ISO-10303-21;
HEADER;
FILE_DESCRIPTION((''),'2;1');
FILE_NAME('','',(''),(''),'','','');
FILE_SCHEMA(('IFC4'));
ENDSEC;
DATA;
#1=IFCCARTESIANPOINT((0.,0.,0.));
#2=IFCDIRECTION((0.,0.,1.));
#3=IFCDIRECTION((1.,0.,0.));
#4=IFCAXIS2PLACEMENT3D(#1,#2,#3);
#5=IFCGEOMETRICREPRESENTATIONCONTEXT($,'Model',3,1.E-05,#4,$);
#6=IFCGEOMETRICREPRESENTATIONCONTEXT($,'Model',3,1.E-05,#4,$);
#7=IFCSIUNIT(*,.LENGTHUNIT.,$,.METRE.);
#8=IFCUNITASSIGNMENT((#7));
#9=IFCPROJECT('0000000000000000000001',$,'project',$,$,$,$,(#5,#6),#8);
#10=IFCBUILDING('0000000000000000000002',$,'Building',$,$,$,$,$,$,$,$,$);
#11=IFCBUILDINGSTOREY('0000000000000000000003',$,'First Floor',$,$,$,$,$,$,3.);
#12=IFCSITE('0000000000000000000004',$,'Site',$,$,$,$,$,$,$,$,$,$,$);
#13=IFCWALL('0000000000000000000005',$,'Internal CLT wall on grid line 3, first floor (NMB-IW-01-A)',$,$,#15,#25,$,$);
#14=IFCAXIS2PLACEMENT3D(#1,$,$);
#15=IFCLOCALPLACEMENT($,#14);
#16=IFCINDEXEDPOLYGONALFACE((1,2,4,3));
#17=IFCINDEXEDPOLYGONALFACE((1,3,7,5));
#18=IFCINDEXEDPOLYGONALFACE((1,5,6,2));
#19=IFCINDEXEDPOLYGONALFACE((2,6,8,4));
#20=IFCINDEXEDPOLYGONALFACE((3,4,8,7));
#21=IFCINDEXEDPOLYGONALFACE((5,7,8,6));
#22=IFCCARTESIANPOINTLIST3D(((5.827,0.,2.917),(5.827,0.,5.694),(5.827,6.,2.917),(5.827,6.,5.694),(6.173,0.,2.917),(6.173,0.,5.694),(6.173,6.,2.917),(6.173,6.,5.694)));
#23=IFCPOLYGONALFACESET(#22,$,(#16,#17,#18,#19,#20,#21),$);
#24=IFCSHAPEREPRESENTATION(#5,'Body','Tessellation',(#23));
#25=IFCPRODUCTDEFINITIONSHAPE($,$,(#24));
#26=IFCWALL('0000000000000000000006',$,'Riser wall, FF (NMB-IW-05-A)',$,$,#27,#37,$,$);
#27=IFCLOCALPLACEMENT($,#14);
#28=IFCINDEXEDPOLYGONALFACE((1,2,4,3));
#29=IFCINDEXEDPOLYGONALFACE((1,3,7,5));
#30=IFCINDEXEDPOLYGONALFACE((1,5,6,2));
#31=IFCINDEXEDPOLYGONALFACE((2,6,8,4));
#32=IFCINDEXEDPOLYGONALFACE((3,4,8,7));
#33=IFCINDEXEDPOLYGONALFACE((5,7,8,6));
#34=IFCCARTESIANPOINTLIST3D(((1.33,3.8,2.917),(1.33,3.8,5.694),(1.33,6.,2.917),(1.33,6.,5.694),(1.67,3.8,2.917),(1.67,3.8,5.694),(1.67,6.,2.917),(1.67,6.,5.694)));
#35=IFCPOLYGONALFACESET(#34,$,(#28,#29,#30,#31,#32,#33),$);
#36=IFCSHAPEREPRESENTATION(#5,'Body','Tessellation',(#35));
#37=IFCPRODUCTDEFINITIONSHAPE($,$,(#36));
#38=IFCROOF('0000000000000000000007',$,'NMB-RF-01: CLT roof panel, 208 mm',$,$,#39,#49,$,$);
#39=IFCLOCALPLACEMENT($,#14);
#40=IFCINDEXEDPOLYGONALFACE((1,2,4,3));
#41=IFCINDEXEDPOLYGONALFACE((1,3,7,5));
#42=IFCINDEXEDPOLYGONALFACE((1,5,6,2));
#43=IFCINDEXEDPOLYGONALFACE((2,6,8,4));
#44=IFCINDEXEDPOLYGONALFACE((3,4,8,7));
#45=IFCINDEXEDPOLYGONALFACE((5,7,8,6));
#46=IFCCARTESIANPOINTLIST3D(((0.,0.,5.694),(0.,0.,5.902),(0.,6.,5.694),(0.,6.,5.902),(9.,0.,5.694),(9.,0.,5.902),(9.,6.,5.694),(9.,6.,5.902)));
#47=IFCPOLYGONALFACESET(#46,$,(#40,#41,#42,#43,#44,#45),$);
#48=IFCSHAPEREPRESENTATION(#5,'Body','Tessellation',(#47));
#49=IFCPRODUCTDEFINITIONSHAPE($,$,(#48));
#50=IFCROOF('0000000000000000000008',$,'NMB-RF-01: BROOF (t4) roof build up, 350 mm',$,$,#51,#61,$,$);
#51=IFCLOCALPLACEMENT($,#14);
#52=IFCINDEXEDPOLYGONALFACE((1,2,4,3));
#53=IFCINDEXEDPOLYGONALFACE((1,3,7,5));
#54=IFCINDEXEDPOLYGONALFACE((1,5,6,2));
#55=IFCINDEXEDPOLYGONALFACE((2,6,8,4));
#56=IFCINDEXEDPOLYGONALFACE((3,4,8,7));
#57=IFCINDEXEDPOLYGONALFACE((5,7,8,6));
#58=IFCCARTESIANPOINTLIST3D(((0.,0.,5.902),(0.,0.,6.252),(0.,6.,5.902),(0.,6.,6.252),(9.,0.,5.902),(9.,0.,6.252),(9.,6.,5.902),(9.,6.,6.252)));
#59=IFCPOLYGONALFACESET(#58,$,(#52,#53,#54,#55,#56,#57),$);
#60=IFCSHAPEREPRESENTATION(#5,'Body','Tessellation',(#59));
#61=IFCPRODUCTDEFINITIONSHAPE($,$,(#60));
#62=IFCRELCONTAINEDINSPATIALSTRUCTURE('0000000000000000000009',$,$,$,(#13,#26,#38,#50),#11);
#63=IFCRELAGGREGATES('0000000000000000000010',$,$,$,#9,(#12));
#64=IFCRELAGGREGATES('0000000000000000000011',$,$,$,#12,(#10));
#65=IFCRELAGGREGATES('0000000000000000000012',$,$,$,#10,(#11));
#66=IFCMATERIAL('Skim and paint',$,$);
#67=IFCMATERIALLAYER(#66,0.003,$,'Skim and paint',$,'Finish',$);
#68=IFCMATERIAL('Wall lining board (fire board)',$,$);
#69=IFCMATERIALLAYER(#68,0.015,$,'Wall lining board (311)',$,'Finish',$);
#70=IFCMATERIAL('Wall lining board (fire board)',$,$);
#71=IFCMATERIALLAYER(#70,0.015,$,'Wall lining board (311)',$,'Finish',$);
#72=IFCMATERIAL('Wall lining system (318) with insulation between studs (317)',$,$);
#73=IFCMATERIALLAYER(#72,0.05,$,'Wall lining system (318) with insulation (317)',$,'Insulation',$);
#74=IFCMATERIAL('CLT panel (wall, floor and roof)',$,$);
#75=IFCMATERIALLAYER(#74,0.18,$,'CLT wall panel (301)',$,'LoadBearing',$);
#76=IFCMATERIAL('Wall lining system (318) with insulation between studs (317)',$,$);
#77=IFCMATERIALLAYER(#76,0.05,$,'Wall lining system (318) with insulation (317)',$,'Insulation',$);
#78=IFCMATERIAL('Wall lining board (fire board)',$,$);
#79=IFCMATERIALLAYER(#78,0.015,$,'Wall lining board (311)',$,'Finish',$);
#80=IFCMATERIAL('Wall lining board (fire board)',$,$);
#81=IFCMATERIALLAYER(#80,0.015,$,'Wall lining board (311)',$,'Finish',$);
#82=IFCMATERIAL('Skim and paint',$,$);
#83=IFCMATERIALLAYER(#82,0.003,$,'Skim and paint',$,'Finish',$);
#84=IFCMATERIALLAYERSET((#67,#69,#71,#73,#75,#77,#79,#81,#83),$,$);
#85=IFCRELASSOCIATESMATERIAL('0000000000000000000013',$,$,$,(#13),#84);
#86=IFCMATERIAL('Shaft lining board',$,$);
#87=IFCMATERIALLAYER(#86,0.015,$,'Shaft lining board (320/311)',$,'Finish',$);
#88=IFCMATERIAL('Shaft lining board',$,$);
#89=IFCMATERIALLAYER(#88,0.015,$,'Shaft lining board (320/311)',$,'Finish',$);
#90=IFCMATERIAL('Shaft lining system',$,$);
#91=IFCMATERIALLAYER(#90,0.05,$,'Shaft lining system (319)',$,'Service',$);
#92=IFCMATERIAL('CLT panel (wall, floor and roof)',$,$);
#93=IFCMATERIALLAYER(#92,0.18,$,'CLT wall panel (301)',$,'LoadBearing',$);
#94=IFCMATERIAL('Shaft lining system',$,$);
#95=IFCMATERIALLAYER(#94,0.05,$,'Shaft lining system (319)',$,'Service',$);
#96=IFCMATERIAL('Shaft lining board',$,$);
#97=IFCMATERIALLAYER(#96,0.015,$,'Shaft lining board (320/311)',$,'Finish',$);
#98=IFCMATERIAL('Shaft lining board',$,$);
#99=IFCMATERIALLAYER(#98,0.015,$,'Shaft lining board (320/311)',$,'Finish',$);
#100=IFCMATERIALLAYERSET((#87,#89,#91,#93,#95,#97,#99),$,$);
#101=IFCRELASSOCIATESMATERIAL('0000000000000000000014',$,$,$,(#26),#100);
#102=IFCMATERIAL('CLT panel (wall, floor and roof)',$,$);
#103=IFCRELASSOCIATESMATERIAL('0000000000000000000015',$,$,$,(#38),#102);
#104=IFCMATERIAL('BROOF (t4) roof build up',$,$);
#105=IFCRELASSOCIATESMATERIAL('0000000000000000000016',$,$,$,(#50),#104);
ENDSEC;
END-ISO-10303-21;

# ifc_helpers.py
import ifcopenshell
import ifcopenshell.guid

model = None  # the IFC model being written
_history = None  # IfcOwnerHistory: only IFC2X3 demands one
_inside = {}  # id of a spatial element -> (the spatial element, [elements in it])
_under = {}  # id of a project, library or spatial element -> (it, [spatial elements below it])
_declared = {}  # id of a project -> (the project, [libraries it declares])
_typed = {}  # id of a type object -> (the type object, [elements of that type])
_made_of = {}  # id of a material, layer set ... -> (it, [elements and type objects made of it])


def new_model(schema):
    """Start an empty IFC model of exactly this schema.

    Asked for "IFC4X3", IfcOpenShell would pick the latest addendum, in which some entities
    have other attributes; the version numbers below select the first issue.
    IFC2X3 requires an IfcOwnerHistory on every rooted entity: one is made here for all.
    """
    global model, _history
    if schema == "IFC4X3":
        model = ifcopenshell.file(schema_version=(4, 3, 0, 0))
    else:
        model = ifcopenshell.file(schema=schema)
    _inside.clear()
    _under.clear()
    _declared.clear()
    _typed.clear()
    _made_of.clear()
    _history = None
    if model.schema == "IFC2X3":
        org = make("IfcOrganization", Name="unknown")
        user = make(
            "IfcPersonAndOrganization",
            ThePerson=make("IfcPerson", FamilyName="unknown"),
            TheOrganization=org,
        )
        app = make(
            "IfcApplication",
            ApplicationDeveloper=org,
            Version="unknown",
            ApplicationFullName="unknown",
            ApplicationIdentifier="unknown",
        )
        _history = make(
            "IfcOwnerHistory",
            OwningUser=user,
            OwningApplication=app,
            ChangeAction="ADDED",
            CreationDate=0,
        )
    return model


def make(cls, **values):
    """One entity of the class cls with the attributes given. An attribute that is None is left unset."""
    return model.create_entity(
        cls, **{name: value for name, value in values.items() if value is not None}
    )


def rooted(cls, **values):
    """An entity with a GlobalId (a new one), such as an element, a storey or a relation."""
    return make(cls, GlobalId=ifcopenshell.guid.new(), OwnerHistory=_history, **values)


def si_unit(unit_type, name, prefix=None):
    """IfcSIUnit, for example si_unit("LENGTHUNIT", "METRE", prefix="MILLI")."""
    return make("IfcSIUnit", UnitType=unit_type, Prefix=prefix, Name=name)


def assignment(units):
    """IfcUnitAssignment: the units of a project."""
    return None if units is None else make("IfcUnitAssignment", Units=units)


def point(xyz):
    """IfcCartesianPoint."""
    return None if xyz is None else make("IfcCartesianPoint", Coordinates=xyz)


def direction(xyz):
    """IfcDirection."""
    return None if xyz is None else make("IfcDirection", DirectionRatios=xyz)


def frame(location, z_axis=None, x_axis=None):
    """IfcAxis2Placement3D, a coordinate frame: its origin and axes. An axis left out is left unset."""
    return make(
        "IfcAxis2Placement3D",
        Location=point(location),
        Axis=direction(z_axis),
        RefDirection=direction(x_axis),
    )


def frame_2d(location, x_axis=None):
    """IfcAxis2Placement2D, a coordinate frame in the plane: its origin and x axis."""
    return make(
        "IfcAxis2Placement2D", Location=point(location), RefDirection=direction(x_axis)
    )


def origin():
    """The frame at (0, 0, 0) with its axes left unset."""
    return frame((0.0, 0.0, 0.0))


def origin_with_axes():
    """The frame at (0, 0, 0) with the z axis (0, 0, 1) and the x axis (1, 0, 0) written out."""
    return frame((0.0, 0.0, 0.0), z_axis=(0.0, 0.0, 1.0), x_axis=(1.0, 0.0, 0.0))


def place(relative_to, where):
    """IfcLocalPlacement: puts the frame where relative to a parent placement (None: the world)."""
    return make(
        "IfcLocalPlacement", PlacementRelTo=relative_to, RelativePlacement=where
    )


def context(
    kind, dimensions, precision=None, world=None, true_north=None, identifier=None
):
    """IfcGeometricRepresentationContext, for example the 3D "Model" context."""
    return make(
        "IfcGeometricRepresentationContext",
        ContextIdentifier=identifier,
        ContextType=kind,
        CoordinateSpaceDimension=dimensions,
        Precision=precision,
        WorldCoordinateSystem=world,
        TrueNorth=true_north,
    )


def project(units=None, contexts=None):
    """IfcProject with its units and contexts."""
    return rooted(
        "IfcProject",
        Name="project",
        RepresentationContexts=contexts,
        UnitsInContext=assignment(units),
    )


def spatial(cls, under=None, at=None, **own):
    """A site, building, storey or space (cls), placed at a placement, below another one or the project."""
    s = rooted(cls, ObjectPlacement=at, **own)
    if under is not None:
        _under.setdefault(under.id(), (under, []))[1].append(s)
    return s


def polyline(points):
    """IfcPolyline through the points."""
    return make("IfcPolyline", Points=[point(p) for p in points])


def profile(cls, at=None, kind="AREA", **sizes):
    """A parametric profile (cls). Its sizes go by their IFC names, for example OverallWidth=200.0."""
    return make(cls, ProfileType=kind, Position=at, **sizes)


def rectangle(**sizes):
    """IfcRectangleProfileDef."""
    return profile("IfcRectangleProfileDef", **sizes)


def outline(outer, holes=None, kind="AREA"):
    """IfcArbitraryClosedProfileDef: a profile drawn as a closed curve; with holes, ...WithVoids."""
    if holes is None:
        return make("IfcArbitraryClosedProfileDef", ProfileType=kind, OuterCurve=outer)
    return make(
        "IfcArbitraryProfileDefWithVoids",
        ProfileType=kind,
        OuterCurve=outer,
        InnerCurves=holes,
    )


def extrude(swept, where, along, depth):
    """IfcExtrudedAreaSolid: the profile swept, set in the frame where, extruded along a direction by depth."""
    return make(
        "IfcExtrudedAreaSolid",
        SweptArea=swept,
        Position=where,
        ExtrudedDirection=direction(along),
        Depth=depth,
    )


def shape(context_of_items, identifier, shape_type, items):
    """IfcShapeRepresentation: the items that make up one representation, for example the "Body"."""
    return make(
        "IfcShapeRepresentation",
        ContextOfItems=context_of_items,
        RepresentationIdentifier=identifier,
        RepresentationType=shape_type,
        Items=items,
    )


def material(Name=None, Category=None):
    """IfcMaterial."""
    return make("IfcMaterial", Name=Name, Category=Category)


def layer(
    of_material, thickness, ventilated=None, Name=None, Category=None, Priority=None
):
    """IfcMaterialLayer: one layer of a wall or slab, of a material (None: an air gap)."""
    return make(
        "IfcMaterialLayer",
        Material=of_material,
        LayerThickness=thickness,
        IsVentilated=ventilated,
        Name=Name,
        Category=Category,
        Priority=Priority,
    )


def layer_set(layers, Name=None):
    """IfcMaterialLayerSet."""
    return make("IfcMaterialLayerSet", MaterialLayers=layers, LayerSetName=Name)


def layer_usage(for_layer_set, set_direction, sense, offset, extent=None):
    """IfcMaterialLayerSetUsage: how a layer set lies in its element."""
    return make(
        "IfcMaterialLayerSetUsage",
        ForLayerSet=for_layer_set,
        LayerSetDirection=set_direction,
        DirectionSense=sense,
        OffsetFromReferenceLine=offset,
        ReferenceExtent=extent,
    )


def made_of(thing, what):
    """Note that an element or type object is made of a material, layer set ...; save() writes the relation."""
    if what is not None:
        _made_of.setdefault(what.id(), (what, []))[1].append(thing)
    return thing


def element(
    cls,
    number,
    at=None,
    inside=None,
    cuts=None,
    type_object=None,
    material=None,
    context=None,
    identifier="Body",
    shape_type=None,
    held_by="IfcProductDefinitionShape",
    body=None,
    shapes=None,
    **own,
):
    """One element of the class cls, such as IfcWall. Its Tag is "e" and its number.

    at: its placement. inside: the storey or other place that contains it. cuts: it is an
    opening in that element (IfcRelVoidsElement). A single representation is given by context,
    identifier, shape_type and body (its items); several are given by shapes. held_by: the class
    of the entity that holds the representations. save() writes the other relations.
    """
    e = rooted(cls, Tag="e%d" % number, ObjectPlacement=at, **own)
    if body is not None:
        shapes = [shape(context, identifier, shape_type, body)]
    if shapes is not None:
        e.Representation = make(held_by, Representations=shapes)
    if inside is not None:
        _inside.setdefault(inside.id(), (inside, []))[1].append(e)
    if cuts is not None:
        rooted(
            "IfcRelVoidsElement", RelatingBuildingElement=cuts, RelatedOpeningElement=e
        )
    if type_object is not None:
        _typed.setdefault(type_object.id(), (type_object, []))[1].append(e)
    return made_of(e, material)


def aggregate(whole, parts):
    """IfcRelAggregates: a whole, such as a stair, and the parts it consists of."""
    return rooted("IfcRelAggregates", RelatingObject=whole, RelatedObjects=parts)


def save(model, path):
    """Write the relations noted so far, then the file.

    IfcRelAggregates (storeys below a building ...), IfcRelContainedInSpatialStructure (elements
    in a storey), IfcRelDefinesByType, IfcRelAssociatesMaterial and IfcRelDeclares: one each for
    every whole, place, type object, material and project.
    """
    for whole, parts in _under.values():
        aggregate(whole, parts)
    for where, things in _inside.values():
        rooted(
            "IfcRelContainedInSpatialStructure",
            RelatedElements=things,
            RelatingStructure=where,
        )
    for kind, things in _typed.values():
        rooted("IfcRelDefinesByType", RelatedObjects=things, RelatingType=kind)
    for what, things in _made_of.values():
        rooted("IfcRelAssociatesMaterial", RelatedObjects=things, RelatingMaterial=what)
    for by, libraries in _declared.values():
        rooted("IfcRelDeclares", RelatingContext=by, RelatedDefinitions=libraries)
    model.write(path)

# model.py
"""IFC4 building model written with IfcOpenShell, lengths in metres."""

from ifc_helpers import new_model, si_unit, frame, frame_2d, origin, origin_with_axes, place, context, project, spatial, polyline, rectangle, outline, extrude, material, layer, layer_set, layer_usage, element, save


model = new_model("IFC4")

# Units and contexts
model_context_1 = context("Model", 3, precision=1e-05, world=origin_with_axes())
model_context_2 = context("Model", 3, precision=1e-05, world=origin_with_axes())
ifc_project = project(units=[si_unit("LENGTHUNIT", "METRE")], contexts=[model_context_1, model_context_2])

# Site, building, storey
site = spatial("IfcSite", under=ifc_project, Name="Site")
building = spatial("IfcBuilding", under=site, Name="Building")
storey = spatial("IfcBuildingStorey", under=building, Name="First Floor", Elevation=3.0)

# Walls
ifc_material_1 = material(Name="Skim and paint")
ifc_layer_1 = layer(ifc_material_1, 0.003, Name="Skim and paint", Category="Finish")
ifc_material_2 = material(Name="Wall lining board (fire board)")
ifc_layer_2 = layer(ifc_material_2, 0.015, Name="Wall lining board (311)", Category="Finish")
ifc_material_3 = material(Name="Wall lining board (fire board)")
ifc_layer_3 = layer(ifc_material_3, 0.015, Name="Wall lining board (311)", Category="Finish")
ifc_material_4 = material(Name="Wall lining system (318) with insulation between studs (317)")
ifc_layer_4 = layer(ifc_material_4, 0.05, Name="Wall lining system (318) with insulation (317)", Category="Insulation")
ifc_material_5 = material(Name="CLT panel (wall, floor and roof)")
ifc_layer_5 = layer(ifc_material_5, 0.18, Name="CLT wall panel (301)", Category="LoadBearing")
ifc_material_6 = material(Name="Wall lining system (318) with insulation between studs (317)")
ifc_layer_6 = layer(ifc_material_6, 0.05, Name="Wall lining system (318) with insulation (317)", Category="Insulation")
ifc_material_7 = material(Name="Wall lining board (fire board)")
ifc_layer_7 = layer(ifc_material_7, 0.015, Name="Wall lining board (311)", Category="Finish")
ifc_material_8 = material(Name="Wall lining board (fire board)")
ifc_layer_8 = layer(ifc_material_8, 0.015, Name="Wall lining board (311)", Category="Finish")
ifc_material_9 = material(Name="Skim and paint")
ifc_layer_9 = layer(ifc_material_9, 0.003, Name="Skim and paint", Category="Finish")
ifc_layer_set_1 = layer_set([ifc_layer_1, ifc_layer_2, ifc_layer_3, ifc_layer_4, ifc_layer_5, ifc_layer_6, ifc_layer_7, ifc_layer_8, ifc_layer_9])
ifc_layer_usage_1 = layer_usage(ifc_layer_set_1, "AXIS2", "NEGATIVE", 0.173)
wall_1_placement = place(None, frame((6.0, 0.0, 2.917), z_axis=(0.0, 0.0, 1.0), x_axis=(0.0, 1.0, 0.0)))
element("IfcWall", 1, at=wall_1_placement, inside=storey, material=ifc_layer_usage_1, Name="Internal CLT wall on grid line 3, first floor (NMB-IW-01-A)", context=model_context_1, shape_type="SweptSolid", body=[
    extrude(rectangle(XDim=0.346, YDim=2.777, at=frame_2d((0.0, 1.3885))), frame((0.0, 0.0, 0.0), z_axis=(1.0, 0.0, 0.0), x_axis=(0.0, 1.0, 0.0)), (0.0, 0.0, 1.0), 6.0),
])
ifc_material_10 = material(Name="Shaft lining board")
ifc_layer_10 = layer(ifc_material_10, 0.015, Name="Shaft lining board (320/311)", Category="Finish")
ifc_material_11 = material(Name="Shaft lining board")
ifc_layer_11 = layer(ifc_material_11, 0.015, Name="Shaft lining board (320/311)", Category="Finish")
ifc_material_12 = material(Name="Shaft lining system")
ifc_layer_12 = layer(ifc_material_12, 0.05, Name="Shaft lining system (319)", Category="Service")
ifc_material_13 = material(Name="CLT panel (wall, floor and roof)")
ifc_layer_13 = layer(ifc_material_13, 0.18, Name="CLT wall panel (301)", Category="LoadBearing")
ifc_material_14 = material(Name="Shaft lining system")
ifc_layer_14 = layer(ifc_material_14, 0.05, Name="Shaft lining system (319)", Category="Service")
ifc_material_15 = material(Name="Shaft lining board")
ifc_layer_15 = layer(ifc_material_15, 0.015, Name="Shaft lining board (320/311)", Category="Finish")
ifc_material_16 = material(Name="Shaft lining board")
ifc_layer_16 = layer(ifc_material_16, 0.015, Name="Shaft lining board (320/311)", Category="Finish")
ifc_layer_set_2 = layer_set([ifc_layer_10, ifc_layer_11, ifc_layer_12, ifc_layer_13, ifc_layer_14, ifc_layer_15, ifc_layer_16])
ifc_layer_usage_2 = layer_usage(ifc_layer_set_2, "AXIS2", "NEGATIVE", 0.17)
wall_2_placement = place(None, frame((1.5, 3.8, 2.917), z_axis=(0.0, 0.0, 1.0), x_axis=(0.0, 1.0, 0.0)))
element("IfcWall", 2, at=wall_2_placement, inside=storey, material=ifc_layer_usage_2, Name="Riser wall, FF (NMB-IW-05-A)", context=model_context_1, shape_type="SweptSolid", body=[
    extrude(rectangle(XDim=0.34, YDim=2.777, at=frame_2d((0.0, 1.3885))), frame((0.0, 0.0, 0.0), z_axis=(1.0, 0.0, 0.0), x_axis=(0.0, 1.0, 0.0)), (0.0, 0.0, 1.0), 2.2),
])

# Roofs
ifc_material_17 = material(Name="CLT panel (wall, floor and roof)")
roof_1_placement = place(None, frame((0.0, 0.0, 5.902), z_axis=(0.0, 0.0, 1.0), x_axis=(1.0, 0.0, 0.0)))
element("IfcRoof", 3, at=roof_1_placement, inside=storey, material=ifc_material_17, Name="NMB-RF-01: CLT roof panel, 208 mm", context=model_context_1, shape_type="SweptSolid", body=[
    extrude(outline(polyline([(0.0, 0.0), (0.0, 6.0), (9.0, 6.0), (9.0, 0.0), (0.0, 0.0)])), origin(), (0.0, 0.0, -1.0), 0.208),
])
ifc_material_18 = material(Name="BROOF (t4) roof build up")
roof_2_placement = place(None, frame((0.0, 0.0, 6.252), z_axis=(0.0, 0.0, 1.0), x_axis=(1.0, 0.0, 0.0)))
element("IfcRoof", 4, at=roof_2_placement, inside=storey, material=ifc_material_18, Name="NMB-RF-01: BROOF (t4) roof build up, 350 mm", context=model_context_1, shape_type="SweptSolid", body=[
    extrude(outline(polyline([(0.0, 0.0), (0.0, 6.0), (9.0, 6.0), (9.0, 0.0), (0.0, 0.0)])), origin(), (0.0, 0.0, -1.0), 0.35),
])

save(model, "model.ifc")
